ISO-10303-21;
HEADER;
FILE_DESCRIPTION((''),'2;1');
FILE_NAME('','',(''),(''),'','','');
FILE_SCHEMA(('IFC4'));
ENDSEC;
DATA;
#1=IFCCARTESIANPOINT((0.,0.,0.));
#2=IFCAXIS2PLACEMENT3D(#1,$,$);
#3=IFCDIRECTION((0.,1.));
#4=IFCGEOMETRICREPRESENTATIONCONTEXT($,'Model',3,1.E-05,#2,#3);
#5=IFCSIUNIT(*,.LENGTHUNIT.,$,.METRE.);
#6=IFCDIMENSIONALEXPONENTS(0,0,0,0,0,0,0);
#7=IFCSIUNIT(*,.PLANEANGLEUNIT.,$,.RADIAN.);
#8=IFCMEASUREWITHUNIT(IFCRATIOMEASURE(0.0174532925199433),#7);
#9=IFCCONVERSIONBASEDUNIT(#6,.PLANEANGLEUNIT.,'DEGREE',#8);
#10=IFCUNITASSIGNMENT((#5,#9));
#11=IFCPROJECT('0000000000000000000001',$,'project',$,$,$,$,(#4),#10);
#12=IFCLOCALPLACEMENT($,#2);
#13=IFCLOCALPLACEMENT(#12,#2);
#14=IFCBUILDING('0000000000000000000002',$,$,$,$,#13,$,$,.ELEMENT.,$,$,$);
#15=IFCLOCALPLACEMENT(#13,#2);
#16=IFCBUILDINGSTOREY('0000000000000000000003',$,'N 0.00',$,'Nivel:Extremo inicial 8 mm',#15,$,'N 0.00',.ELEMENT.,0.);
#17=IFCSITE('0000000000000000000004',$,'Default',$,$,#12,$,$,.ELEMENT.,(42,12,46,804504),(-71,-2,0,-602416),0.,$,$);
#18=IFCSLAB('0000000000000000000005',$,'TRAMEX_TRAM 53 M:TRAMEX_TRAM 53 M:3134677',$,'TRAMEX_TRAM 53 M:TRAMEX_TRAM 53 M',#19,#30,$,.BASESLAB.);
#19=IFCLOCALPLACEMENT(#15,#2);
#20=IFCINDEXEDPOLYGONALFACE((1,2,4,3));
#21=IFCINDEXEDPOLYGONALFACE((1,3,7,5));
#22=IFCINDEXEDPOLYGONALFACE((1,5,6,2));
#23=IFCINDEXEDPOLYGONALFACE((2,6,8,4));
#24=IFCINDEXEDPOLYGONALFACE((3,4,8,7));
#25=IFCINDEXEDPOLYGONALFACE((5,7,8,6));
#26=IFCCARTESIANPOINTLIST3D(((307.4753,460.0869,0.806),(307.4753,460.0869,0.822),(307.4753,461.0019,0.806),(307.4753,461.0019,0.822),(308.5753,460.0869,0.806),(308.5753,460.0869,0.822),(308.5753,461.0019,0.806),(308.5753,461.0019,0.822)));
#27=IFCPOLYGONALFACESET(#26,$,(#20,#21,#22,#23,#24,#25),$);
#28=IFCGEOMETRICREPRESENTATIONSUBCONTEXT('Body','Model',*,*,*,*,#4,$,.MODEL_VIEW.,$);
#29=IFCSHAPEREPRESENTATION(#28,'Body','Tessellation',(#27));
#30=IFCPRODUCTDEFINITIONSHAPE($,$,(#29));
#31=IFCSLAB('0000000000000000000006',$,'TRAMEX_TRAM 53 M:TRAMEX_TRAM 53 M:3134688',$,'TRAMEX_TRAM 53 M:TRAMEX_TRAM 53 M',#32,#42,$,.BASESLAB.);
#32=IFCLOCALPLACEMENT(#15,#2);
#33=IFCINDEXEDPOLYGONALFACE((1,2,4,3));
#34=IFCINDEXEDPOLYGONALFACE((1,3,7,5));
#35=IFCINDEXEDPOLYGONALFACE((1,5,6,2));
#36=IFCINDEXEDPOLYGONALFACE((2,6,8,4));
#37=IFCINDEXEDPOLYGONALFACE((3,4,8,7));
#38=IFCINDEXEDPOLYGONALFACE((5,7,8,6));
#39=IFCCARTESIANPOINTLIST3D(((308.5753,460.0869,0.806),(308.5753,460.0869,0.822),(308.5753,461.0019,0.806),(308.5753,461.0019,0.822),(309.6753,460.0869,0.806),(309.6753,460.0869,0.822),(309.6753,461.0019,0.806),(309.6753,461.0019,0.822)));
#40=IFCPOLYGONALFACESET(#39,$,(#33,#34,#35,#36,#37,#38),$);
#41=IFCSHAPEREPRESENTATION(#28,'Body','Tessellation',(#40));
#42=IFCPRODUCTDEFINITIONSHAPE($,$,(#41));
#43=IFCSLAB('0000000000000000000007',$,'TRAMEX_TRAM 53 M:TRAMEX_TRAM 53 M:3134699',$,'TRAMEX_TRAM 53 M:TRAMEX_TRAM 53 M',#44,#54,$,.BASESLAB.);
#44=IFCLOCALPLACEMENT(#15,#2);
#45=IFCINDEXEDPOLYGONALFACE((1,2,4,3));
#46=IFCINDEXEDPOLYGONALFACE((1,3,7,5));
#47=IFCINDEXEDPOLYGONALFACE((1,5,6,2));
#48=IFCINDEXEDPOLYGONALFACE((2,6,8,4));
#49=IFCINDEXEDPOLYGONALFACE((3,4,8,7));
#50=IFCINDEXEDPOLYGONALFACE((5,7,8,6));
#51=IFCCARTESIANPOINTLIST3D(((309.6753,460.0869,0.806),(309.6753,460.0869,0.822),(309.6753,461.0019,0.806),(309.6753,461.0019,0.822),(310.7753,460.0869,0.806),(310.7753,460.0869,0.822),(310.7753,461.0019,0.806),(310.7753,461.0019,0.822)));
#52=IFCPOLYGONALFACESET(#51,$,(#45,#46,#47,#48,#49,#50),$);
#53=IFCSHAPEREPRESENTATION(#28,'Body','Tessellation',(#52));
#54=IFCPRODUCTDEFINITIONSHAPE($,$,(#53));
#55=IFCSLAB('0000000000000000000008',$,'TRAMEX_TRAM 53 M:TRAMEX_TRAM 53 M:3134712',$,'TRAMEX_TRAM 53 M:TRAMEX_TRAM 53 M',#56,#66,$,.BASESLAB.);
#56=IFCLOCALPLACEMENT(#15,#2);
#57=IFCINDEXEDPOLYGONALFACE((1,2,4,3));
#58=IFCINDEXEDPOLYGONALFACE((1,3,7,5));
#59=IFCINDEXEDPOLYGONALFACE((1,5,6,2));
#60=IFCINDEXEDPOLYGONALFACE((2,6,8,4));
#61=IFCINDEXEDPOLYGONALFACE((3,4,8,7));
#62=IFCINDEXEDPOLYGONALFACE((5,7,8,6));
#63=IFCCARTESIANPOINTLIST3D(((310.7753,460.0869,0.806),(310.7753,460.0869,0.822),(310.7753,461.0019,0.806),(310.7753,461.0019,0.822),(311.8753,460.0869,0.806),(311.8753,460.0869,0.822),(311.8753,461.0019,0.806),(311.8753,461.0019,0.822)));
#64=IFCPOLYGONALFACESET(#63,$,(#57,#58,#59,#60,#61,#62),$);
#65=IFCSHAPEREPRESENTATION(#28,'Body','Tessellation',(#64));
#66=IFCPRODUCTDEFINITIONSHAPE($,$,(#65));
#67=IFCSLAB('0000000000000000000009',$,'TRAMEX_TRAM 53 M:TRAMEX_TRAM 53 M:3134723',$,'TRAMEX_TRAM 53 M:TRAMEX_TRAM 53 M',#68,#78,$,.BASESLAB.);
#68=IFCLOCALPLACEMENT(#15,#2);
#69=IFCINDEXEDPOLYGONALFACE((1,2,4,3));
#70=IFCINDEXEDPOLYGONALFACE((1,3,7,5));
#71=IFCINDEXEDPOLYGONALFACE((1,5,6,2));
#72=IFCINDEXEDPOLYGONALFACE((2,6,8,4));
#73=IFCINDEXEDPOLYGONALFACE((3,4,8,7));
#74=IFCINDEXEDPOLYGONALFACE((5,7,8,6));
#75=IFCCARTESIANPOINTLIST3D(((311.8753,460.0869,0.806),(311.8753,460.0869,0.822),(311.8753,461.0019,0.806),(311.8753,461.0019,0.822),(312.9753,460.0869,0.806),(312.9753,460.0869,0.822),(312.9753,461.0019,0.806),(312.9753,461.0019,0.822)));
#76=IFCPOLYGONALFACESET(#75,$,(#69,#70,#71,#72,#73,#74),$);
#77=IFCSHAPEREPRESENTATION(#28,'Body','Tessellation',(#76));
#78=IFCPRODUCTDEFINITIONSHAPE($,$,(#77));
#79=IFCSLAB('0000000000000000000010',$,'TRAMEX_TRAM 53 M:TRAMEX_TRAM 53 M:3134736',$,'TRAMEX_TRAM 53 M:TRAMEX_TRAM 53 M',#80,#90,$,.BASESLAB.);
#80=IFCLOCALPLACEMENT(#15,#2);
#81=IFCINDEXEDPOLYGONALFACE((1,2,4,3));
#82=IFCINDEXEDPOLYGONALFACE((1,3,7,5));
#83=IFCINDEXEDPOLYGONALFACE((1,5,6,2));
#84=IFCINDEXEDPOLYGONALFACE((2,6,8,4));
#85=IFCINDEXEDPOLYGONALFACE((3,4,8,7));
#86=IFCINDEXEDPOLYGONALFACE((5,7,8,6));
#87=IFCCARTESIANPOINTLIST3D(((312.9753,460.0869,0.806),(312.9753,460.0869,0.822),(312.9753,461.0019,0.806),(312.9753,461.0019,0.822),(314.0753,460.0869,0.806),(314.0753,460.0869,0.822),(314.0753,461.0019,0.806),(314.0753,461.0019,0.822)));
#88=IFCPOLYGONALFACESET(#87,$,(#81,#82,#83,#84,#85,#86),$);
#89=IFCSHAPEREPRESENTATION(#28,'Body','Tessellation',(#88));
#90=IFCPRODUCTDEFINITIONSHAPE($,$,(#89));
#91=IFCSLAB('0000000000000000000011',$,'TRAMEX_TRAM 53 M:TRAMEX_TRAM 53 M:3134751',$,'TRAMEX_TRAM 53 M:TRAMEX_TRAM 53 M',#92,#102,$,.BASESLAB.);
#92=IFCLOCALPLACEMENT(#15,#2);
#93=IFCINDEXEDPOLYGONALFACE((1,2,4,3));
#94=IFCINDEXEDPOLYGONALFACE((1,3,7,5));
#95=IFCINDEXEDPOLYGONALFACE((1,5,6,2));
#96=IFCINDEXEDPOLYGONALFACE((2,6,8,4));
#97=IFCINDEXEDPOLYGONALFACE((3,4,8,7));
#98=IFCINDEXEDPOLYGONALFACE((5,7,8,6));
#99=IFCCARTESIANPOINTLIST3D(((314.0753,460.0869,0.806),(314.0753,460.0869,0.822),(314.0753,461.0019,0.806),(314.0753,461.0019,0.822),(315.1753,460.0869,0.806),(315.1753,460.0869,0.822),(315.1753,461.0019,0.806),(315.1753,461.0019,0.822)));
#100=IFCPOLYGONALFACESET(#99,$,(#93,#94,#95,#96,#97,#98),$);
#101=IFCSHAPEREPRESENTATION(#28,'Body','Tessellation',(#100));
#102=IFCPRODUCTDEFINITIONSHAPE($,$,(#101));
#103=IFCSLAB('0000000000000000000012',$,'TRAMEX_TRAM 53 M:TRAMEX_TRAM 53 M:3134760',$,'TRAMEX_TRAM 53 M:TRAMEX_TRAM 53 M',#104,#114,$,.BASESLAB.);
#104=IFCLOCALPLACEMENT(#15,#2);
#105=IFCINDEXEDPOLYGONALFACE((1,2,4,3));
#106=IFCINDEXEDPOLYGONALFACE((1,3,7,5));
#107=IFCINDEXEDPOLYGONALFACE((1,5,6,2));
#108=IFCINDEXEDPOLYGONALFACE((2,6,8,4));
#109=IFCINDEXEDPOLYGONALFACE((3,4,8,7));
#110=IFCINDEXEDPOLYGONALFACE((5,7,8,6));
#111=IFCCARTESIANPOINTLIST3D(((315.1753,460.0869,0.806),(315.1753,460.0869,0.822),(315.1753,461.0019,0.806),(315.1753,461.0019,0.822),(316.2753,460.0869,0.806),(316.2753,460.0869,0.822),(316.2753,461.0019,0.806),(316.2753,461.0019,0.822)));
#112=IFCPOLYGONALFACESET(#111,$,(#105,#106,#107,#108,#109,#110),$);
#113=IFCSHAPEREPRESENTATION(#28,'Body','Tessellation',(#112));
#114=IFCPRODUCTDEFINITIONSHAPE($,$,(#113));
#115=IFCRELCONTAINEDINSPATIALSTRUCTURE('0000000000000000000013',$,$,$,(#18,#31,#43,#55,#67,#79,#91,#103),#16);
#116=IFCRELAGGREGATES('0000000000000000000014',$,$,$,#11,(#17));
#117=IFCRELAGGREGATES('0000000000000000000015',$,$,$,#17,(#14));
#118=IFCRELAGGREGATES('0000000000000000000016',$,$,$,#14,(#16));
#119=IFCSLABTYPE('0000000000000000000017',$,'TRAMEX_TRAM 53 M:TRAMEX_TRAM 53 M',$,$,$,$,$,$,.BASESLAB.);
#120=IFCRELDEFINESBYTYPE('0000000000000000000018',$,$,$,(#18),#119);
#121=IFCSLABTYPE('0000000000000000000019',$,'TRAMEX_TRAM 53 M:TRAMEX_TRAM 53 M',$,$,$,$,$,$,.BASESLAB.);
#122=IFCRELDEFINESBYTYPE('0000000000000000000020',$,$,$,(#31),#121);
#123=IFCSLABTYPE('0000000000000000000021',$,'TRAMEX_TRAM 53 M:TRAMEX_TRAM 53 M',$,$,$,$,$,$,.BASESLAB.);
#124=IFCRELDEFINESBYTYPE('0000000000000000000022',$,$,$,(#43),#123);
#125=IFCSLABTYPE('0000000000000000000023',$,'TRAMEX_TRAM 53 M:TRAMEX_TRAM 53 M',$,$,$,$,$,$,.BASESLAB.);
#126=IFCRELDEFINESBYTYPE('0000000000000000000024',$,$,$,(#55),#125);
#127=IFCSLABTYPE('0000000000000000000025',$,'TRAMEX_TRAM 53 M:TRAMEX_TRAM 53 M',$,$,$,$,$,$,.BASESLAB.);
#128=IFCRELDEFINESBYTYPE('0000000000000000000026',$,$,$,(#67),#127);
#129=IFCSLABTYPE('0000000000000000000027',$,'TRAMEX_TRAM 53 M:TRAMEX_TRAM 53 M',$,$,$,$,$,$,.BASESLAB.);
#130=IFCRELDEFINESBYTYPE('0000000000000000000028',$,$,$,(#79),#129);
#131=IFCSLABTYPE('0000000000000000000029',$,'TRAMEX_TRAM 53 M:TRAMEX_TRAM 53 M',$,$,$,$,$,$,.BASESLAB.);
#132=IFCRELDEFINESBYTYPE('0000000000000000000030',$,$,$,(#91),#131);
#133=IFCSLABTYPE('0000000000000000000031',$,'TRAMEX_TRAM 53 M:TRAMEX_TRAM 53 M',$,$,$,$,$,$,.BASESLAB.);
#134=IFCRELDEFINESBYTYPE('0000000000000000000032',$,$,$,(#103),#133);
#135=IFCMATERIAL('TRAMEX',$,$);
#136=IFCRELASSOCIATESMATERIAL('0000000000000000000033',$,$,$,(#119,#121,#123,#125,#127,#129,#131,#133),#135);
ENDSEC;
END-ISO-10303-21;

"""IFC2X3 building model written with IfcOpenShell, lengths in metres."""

from ifc_helpers import new_model, entity, si_unit, converted_unit, direction, frame, frame_2d, origin, place, context, subcontext, project, spatial, rectangle, extrude, material, type_object, element, save


model = new_model("IFC2X3")

# Units and contexts
model_context = context("Model", 3, precision=1e-05, world=origin(), true_north=direction((0.0, 1.0)))
body_context = subcontext(model_context, "Body", "Model", "MODEL_VIEW")
ifc_project = project(units=[si_unit("LENGTHUNIT", "METRE"), converted_unit("PLANEANGLEUNIT", "DEGREE", entity("IfcRatioMeasure", 0.0174532925199433), si_unit("PLANEANGLEUNIT", "RADIAN"), dimensions=[0, 0, 0, 0, 0, 0, 0])], contexts=[model_context])

# Site, building, storey
site_placement = place(None, origin())
site = spatial("IfcSite", under=ifc_project, at=site_placement, Name="Default", CompositionType="ELEMENT", RefLatitude=(42, 12, 46, 804504), RefLongitude=(-71, -2, 0, -602416), RefElevation=0.0)
building_placement = place(site_placement, origin())
building = spatial("IfcBuilding", under=site, at=building_placement, CompositionType="ELEMENT")
storey_placement = place(building_placement, origin())
storey = spatial("IfcBuildingStorey", under=building, at=storey_placement, Name="N 0.00", ObjectType="Nivel:Extremo inicial 8 mm", LongName="N 0.00", CompositionType="ELEMENT", Elevation=0.0)

# Slabs
ifc_material = material(Name="TRAMEX")
slab_type_1 = type_object("IfcSlabType", Name="TRAMEX_TRAM 53 M:TRAMEX_TRAM 53 M", PredefinedType="BASESLAB", material=ifc_material)
slab_1_placement = place(storey_placement, origin())
element("IfcSlab", 1, at=slab_1_placement, inside=storey, type_object=slab_type_1, Name="TRAMEX_TRAM 53 M:TRAMEX_TRAM 53 M:3134677", ObjectType="TRAMEX_TRAM 53 M:TRAMEX_TRAM 53 M", PredefinedType="BASESLAB", context=body_context, shape_type="SweptSolid", body=[
    extrude(rectangle(XDim=0.915, YDim=1.1, at=frame_2d((0.0, 0.0), x_axis=(1.0, 0.0))), frame((308.0253, 460.5444, 0.806), z_axis=(0.0, 0.0, 1.0), x_axis=(0.0, 1.0, 0.0)), (0.0, 0.0, 1.0), 0.016),
])
slab_type_2 = type_object("IfcSlabType", Name="TRAMEX_TRAM 53 M:TRAMEX_TRAM 53 M", PredefinedType="BASESLAB", material=ifc_material)
slab_2_placement = place(storey_placement, origin())
element("IfcSlab", 2, at=slab_2_placement, inside=storey, type_object=slab_type_2, Name="TRAMEX_TRAM 53 M:TRAMEX_TRAM 53 M:3134688", ObjectType="TRAMEX_TRAM 53 M:TRAMEX_TRAM 53 M", PredefinedType="BASESLAB", context=body_context, shape_type="SweptSolid", body=[
    extrude(rectangle(XDim=0.915, YDim=1.1, at=frame_2d((0.0, 0.0), x_axis=(1.0, 0.0))), frame((309.1253, 460.5444, 0.806), z_axis=(0.0, 0.0, 1.0), x_axis=(0.0, 1.0, 0.0)), (0.0, 0.0, 1.0), 0.016),
])
slab_type_3 = type_object("IfcSlabType", Name="TRAMEX_TRAM 53 M:TRAMEX_TRAM 53 M", PredefinedType="BASESLAB", material=ifc_material)
slab_3_placement = place(storey_placement, origin())
element("IfcSlab", 3, at=slab_3_placement, inside=storey, type_object=slab_type_3, Name="TRAMEX_TRAM 53 M:TRAMEX_TRAM 53 M:3134699", ObjectType="TRAMEX_TRAM 53 M:TRAMEX_TRAM 53 M", PredefinedType="BASESLAB", context=body_context, shape_type="SweptSolid", body=[
    extrude(rectangle(XDim=0.915, YDim=1.1, at=frame_2d((0.0, 0.0), x_axis=(1.0, 0.0))), frame((310.2253, 460.5444, 0.806), z_axis=(0.0, 0.0, 1.0), x_axis=(0.0, 1.0, 0.0)), (0.0, 0.0, 1.0), 0.016),
])
slab_type_4 = type_object("IfcSlabType", Name="TRAMEX_TRAM 53 M:TRAMEX_TRAM 53 M", PredefinedType="BASESLAB", material=ifc_material)
slab_4_placement = place(storey_placement, origin())
element("IfcSlab", 4, at=slab_4_placement, inside=storey, type_object=slab_type_4, Name="TRAMEX_TRAM 53 M:TRAMEX_TRAM 53 M:3134712", ObjectType="TRAMEX_TRAM 53 M:TRAMEX_TRAM 53 M", PredefinedType="BASESLAB", context=body_context, shape_type="SweptSolid", body=[
    extrude(rectangle(XDim=0.915, YDim=1.1, at=frame_2d((0.0, 0.0), x_axis=(1.0, 0.0))), frame((311.3253, 460.5444, 0.806), z_axis=(0.0, 0.0, 1.0), x_axis=(0.0, 1.0, 0.0)), (0.0, 0.0, 1.0), 0.016),
])
slab_type_5 = type_object("IfcSlabType", Name="TRAMEX_TRAM 53 M:TRAMEX_TRAM 53 M", PredefinedType="BASESLAB", material=ifc_material)
slab_5_placement = place(storey_placement, origin())
element("IfcSlab", 5, at=slab_5_placement, inside=storey, type_object=slab_type_5, Name="TRAMEX_TRAM 53 M:TRAMEX_TRAM 53 M:3134723", ObjectType="TRAMEX_TRAM 53 M:TRAMEX_TRAM 53 M", PredefinedType="BASESLAB", context=body_context, shape_type="SweptSolid", body=[
    extrude(rectangle(XDim=0.915, YDim=1.1, at=frame_2d((0.0, 0.0), x_axis=(1.0, 0.0))), frame((312.4253, 460.5444, 0.806), z_axis=(0.0, 0.0, 1.0), x_axis=(0.0, 1.0, 0.0)), (0.0, 0.0, 1.0), 0.016),
])
slab_type_6 = type_object("IfcSlabType", Name="TRAMEX_TRAM 53 M:TRAMEX_TRAM 53 M", PredefinedType="BASESLAB", material=ifc_material)
slab_6_placement = place(storey_placement, origin())
element("IfcSlab", 6, at=slab_6_placement, inside=storey, type_object=slab_type_6, Name="TRAMEX_TRAM 53 M:TRAMEX_TRAM 53 M:3134736", ObjectType="TRAMEX_TRAM 53 M:TRAMEX_TRAM 53 M", PredefinedType="BASESLAB", context=body_context, shape_type="SweptSolid", body=[
    extrude(rectangle(XDim=0.915, YDim=1.1, at=frame_2d((0.0, 0.0), x_axis=(1.0, 0.0))), frame((313.5253, 460.5444, 0.806), z_axis=(0.0, 0.0, 1.0), x_axis=(0.0, 1.0, 0.0)), (0.0, 0.0, 1.0), 0.016),
])
slab_type_7 = type_object("IfcSlabType", Name="TRAMEX_TRAM 53 M:TRAMEX_TRAM 53 M", PredefinedType="BASESLAB", material=ifc_material)
slab_7_placement = place(storey_placement, origin())
element("IfcSlab", 7, at=slab_7_placement, inside=storey, type_object=slab_type_7, Name="TRAMEX_TRAM 53 M:TRAMEX_TRAM 53 M:3134751", ObjectType="TRAMEX_TRAM 53 M:TRAMEX_TRAM 53 M", PredefinedType="BASESLAB", context=body_context, shape_type="SweptSolid", body=[
    extrude(rectangle(XDim=0.915, YDim=1.1, at=frame_2d((0.0, 0.0), x_axis=(1.0, 0.0))), frame((314.6253, 460.5444, 0.806), z_axis=(0.0, 0.0, 1.0), x_axis=(0.0, 1.0, 0.0)), (0.0, 0.0, 1.0), 0.016),
])
slab_type_8 = type_object("IfcSlabType", Name="TRAMEX_TRAM 53 M:TRAMEX_TRAM 53 M", PredefinedType="BASESLAB", material=ifc_material)
slab_8_placement = place(storey_placement, origin())
element("IfcSlab", 8, at=slab_8_placement, inside=storey, type_object=slab_type_8, Name="TRAMEX_TRAM 53 M:TRAMEX_TRAM 53 M:3134760", ObjectType="TRAMEX_TRAM 53 M:TRAMEX_TRAM 53 M", PredefinedType="BASESLAB", context=body_context, shape_type="SweptSolid", body=[
    extrude(rectangle(XDim=0.915, YDim=1.1, at=frame_2d((0.0, 0.0), x_axis=(1.0, 0.0))), frame((315.7253, 460.5444, 0.806), z_axis=(0.0, 0.0, 1.0), x_axis=(0.0, 1.0, 0.0)), (0.0, 0.0, 1.0), 0.016),
])

save(model, "model.ifc")
